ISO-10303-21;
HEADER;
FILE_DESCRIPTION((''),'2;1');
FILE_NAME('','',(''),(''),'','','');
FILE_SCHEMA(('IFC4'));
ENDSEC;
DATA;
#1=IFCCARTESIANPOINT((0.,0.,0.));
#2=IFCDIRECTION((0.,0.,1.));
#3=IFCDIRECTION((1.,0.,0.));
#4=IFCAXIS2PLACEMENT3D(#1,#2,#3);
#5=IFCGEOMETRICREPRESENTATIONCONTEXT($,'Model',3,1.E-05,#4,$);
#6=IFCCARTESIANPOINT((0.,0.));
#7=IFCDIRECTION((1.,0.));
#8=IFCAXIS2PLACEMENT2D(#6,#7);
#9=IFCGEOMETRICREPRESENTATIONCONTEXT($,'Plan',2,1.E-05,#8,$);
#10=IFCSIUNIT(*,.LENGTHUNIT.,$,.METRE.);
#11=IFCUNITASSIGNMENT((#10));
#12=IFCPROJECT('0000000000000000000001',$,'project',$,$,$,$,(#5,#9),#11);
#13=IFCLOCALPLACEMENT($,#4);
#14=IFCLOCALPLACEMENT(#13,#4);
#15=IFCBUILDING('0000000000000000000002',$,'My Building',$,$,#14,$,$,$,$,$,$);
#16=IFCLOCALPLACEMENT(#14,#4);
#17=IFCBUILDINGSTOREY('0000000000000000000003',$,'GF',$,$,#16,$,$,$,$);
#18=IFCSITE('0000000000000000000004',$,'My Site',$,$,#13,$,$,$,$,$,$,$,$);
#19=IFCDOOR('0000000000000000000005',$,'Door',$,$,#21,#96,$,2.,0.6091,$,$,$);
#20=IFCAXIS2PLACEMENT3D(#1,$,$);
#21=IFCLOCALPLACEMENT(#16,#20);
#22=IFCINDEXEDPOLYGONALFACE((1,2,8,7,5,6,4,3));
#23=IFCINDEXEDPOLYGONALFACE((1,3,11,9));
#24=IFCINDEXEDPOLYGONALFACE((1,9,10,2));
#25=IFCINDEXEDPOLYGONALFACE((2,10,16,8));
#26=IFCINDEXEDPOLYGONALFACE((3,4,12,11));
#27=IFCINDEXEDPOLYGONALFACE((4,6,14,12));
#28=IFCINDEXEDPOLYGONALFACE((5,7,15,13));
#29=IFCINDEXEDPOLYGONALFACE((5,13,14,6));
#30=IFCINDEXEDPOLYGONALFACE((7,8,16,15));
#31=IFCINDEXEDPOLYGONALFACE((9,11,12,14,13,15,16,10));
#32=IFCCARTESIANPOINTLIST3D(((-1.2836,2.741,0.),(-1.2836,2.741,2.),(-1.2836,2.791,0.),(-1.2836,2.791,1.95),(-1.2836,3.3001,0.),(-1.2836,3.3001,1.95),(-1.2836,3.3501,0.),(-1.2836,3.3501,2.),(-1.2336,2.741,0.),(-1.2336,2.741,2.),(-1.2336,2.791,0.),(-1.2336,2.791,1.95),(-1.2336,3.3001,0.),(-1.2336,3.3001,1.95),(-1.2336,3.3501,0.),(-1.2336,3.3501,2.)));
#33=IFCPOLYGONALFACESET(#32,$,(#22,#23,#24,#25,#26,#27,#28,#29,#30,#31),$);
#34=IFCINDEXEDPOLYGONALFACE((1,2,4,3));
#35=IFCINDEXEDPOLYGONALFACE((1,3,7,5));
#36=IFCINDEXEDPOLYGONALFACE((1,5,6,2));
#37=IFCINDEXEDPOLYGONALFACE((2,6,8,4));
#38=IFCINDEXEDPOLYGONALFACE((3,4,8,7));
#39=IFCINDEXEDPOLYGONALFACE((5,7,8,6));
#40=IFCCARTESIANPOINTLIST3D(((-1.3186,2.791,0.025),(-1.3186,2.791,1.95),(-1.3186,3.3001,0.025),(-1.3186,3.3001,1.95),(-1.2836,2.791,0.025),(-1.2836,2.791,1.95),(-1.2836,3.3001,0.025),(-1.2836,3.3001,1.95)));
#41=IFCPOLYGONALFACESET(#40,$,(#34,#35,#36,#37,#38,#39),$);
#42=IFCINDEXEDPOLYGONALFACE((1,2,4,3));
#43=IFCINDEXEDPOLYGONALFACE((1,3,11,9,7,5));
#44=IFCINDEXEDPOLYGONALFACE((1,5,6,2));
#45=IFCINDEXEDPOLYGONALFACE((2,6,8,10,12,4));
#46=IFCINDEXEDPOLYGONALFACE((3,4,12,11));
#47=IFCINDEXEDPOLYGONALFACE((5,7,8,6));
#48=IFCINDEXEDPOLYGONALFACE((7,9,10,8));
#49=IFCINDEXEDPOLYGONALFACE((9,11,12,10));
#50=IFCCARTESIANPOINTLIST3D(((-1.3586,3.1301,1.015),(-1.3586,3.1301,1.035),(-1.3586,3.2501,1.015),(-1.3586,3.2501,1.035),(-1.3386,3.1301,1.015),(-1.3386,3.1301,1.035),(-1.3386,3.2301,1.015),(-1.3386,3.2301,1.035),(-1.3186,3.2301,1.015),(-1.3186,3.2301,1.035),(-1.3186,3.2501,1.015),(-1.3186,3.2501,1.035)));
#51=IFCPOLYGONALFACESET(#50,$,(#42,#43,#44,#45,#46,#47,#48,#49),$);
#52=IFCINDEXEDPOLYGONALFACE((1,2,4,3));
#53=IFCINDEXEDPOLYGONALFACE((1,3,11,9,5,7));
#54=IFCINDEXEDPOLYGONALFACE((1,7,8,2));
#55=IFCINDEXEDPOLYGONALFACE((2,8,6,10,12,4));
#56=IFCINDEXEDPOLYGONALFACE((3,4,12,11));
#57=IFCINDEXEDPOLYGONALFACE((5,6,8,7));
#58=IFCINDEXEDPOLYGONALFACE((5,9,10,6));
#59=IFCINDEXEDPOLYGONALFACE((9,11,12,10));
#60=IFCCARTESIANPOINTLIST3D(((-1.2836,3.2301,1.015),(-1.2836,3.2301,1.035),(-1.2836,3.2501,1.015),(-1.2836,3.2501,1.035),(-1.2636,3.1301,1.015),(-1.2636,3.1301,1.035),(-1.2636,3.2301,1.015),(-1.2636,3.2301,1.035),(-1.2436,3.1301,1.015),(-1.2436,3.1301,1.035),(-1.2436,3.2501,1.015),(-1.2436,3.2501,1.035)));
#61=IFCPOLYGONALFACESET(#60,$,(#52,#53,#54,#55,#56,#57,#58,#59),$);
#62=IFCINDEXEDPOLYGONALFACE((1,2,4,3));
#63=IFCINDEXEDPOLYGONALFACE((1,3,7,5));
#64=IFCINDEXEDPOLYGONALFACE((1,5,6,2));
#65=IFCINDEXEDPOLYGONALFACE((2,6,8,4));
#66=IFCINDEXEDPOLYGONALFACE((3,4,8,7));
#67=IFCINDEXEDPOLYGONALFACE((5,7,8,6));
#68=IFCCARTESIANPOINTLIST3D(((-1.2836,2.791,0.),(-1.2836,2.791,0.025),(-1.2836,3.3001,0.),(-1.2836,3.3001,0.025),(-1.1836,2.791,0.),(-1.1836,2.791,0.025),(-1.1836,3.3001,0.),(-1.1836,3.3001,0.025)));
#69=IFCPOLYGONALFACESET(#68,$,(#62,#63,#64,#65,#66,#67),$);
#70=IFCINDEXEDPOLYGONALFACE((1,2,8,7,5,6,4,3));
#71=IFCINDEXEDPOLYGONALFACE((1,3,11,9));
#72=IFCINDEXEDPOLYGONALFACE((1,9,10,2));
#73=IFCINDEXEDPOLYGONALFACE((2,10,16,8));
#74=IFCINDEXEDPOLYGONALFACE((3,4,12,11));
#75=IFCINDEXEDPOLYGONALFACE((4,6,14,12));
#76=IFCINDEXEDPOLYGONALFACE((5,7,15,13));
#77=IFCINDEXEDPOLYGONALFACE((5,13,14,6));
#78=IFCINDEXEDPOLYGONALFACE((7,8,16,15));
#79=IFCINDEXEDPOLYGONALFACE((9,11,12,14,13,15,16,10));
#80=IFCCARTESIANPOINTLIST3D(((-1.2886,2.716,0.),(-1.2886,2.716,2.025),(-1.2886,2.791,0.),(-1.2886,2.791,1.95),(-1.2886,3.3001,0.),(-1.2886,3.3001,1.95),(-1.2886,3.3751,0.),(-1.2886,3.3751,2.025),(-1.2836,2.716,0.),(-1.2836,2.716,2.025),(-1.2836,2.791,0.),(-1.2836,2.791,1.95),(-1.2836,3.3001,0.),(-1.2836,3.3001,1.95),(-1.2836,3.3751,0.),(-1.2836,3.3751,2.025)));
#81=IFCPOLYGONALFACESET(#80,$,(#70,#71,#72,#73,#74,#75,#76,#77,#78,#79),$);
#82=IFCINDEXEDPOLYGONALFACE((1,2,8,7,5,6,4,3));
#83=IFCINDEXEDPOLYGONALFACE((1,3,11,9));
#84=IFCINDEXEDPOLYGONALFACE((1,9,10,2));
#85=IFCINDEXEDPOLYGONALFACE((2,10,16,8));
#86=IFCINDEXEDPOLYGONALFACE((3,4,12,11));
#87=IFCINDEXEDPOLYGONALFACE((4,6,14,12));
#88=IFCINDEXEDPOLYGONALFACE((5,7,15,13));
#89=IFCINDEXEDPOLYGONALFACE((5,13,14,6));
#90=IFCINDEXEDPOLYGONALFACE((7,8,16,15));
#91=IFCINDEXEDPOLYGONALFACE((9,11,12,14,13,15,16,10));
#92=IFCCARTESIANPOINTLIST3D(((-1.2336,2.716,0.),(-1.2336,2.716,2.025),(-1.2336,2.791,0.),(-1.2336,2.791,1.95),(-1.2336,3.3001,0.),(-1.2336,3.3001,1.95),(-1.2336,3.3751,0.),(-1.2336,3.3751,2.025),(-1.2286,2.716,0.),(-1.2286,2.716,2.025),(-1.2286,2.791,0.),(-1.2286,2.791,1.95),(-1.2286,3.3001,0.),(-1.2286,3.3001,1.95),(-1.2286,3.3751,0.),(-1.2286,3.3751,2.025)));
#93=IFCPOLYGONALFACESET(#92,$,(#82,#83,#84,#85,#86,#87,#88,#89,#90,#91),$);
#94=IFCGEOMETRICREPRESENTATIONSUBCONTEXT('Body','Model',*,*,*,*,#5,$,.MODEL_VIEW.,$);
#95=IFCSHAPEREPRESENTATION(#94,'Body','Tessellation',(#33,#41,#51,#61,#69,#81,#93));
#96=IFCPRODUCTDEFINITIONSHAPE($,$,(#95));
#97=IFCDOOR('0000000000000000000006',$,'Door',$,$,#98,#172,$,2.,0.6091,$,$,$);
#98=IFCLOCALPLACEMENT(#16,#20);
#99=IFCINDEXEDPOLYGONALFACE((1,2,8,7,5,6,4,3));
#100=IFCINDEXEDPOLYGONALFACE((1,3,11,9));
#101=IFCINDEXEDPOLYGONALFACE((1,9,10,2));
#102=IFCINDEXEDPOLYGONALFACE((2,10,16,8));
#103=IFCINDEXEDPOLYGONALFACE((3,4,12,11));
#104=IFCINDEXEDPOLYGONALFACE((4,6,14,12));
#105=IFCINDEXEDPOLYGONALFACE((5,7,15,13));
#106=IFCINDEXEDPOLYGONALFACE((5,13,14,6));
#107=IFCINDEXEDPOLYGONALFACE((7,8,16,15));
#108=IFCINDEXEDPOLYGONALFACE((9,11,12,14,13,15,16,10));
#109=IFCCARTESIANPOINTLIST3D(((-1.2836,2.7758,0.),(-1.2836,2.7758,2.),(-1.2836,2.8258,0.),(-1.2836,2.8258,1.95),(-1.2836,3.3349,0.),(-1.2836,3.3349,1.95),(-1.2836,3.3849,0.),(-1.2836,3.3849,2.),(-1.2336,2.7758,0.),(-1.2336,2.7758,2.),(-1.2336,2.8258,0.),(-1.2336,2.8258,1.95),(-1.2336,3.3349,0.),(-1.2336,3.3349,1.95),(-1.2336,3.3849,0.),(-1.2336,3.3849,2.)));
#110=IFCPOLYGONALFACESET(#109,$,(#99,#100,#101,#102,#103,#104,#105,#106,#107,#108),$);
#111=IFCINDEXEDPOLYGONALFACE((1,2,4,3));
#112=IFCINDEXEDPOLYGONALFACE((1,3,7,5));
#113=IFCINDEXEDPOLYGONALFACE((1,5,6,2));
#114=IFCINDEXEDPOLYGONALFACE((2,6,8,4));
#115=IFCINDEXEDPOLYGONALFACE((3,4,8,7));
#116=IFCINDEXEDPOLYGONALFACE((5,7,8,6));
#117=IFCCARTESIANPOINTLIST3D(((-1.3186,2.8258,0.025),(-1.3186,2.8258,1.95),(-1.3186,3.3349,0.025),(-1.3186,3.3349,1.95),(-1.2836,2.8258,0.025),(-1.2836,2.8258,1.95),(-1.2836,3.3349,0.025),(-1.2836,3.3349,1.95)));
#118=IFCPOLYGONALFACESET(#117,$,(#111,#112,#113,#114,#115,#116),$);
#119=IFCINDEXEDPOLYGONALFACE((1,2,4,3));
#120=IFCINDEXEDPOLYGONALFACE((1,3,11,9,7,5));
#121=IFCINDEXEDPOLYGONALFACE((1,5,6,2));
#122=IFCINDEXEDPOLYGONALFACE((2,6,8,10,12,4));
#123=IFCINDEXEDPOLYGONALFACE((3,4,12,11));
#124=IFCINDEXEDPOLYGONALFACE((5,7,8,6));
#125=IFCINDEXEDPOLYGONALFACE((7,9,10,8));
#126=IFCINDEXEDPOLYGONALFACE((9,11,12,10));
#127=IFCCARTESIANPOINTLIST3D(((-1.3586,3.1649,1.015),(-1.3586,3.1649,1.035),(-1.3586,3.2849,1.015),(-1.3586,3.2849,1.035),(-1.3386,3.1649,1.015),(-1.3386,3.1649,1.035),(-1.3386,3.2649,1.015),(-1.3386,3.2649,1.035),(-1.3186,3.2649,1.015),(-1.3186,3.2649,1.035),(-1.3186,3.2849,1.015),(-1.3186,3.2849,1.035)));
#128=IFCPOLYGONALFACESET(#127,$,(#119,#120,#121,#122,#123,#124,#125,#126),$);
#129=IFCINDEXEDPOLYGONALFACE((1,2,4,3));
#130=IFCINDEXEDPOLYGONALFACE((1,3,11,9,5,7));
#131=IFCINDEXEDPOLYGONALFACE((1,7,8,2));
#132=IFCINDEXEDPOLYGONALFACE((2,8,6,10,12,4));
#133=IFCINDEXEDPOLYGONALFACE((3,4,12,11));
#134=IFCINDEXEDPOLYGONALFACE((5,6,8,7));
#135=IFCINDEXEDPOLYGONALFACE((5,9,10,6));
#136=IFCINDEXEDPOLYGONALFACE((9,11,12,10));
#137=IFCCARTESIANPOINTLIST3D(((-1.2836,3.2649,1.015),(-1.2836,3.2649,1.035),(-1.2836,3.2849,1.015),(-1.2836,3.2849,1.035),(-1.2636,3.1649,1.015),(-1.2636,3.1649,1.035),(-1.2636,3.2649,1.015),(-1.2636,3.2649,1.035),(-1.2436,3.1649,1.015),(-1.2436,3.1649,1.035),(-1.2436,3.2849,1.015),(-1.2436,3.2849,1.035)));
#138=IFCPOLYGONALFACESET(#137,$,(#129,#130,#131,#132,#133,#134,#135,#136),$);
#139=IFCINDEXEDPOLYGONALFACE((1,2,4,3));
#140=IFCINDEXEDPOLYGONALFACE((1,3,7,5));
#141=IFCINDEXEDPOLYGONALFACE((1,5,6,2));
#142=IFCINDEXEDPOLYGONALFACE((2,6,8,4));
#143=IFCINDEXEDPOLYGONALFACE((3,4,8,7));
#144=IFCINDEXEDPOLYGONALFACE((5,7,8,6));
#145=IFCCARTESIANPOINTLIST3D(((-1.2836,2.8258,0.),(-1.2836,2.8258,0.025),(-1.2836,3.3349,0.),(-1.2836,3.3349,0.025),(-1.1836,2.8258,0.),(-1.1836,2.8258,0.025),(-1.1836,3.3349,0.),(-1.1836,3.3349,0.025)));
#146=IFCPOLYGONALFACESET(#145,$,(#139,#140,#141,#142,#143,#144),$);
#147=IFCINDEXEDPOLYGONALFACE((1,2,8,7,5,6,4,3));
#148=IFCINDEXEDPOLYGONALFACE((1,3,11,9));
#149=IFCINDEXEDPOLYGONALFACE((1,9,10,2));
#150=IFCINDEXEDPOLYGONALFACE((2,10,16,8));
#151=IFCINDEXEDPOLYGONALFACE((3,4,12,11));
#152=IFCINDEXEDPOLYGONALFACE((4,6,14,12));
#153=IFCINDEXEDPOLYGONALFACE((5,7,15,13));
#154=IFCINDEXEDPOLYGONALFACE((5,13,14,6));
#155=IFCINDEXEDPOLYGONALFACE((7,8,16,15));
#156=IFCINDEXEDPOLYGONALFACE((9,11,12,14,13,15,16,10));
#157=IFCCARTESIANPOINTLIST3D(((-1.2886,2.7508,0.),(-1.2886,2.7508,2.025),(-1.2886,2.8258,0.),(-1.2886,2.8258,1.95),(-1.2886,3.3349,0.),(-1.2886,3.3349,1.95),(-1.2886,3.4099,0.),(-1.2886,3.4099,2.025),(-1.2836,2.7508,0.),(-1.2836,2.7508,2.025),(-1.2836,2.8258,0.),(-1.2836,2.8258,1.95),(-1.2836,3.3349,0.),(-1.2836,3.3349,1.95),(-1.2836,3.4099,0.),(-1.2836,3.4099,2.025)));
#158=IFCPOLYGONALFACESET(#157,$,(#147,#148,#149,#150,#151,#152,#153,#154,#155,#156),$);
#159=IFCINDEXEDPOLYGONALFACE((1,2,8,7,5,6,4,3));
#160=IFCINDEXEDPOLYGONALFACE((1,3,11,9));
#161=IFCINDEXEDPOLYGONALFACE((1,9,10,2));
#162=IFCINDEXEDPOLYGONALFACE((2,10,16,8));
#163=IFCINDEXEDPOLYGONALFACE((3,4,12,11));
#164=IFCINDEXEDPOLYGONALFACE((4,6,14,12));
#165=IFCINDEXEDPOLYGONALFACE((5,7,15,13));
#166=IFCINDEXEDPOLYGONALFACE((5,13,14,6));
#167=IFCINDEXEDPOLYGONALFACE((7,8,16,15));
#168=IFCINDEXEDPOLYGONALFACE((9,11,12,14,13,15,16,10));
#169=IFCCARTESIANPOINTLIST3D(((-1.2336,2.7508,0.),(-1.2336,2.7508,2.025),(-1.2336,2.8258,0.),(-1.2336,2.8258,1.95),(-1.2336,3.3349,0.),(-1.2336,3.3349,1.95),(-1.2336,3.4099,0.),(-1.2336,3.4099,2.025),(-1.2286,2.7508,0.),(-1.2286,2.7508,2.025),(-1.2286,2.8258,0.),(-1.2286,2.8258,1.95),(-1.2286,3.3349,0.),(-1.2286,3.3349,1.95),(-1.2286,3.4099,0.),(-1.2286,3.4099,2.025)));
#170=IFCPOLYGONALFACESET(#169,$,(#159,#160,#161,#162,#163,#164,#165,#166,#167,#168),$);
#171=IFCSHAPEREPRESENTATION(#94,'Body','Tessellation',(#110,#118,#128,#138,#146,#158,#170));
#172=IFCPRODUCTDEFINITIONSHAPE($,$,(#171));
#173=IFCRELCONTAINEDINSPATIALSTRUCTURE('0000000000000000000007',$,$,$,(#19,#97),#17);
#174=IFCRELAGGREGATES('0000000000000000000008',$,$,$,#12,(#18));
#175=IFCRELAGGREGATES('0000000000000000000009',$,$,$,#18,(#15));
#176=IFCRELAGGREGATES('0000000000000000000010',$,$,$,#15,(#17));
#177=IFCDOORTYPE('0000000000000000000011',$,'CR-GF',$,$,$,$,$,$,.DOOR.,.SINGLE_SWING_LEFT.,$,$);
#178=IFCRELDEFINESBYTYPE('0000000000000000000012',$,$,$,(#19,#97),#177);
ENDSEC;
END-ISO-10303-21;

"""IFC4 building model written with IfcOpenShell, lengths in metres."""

from ifc_helpers import new_model, entity, si_unit, frame, origin_with_axes, origin_2d_with_axis, place, context, subcontext, project, spatial, line, indexed_curve, outline, extrude, shape, source, transform, mapped, type_object, type_shapes, element, save


model = new_model("IFC4")

# Units and contexts
model_context = context("Model", 3, precision=1e-05, world=origin_with_axes())
plan_context = context("Plan", 2, precision=1e-05, world=origin_2d_with_axis())
body_context_1 = subcontext(model_context, "Body", "Model", "MODEL_VIEW")
body_context_2 = subcontext(plan_context, "Body", "Plan", "PLAN_VIEW")
ifc_project = project(units=[si_unit("LENGTHUNIT", "METRE")], contexts=[model_context, plan_context])

# Site, building, storey
site_placement = place(None, origin_with_axes())
site = spatial("IfcSite", under=ifc_project, at=site_placement, Name="My Site")
building_placement = place(site_placement, origin_with_axes())
building = spatial("IfcBuilding", under=site, at=building_placement, Name="My Building")
storey_placement = place(building_placement, origin_with_axes())
storey = spatial("IfcBuildingStorey", under=building, at=storey_placement, Name="GF")

# Doors
door_type_1 = type_object("IfcDoorType", Name="CR-GF", OperationType="SINGLE_SWING_LEFT", PredefinedType="DOOR")
shared_shape_1 = source(origin_with_axes(), body_context_1, "Body", "SweptSolid", [
    extrude(outline(indexed_curve([(0.0, 0.0), (0.0, 2.0), (0.6091, 2.0), (0.6091, 0.0), (0.5591, 0.0), (0.5591, 1.95), (0.05, 1.95), (0.05, 0.0)], segments=[line(1, 2, 3, 4, 5, 6, 7, 8, 1)])), frame((0.0, 0.0, 0.0), z_axis=(0.0, -1.0, 0.0), x_axis=(1.0, 0.0, 0.0)), (0.0, 0.0, -1.0), 0.05),
    extrude(outline(indexed_curve([(0.0, 0.0), (0.5091, 0.0), (0.5091, 0.035), (0.0, 0.035)], segments=[line(1, 2, 3, 4, 1)])), frame((0.05, -0.035, 0.025), z_axis=(0.0, 0.0, 1.0), x_axis=(1.0, 0.0, 0.0)), (0.0, 0.0, 1.0), 1.925),
    extrude(outline(indexed_curve([(0.0, 0.0), (0.0, -0.04), (0.12, -0.04), (0.12, -0.02), (0.02, -0.02), (0.02, 0.0)], segments=[line(1, 2, 3, 4, 5, 6, 1)])), frame((0.1, -0.035, 1.015), z_axis=(0.0, 0.0, 1.0), x_axis=(1.0, 0.0, 0.0)), (0.0, 0.0, 1.0), 0.02),
    extrude(outline(indexed_curve([(0.0, 0.0), (0.0, 0.04), (0.12, 0.04), (0.12, 0.02), (0.02, 0.02), (0.02, 0.0)], segments=[line(1, 2, 3, 4, 5, 6, 1)])), frame((0.1, 0.0, 1.015), z_axis=(0.0, 0.0, 1.0), x_axis=(1.0, 0.0, 0.0)), (0.0, 0.0, 1.0), 0.02),
    extrude(outline(indexed_curve([(0.0, 0.0), (0.5091, 0.0), (0.5091, 0.1), (0.0, 0.1)], segments=[line(1, 2, 3, 4, 1)])), frame((0.05, 0.0, 0.0), z_axis=(0.0, 0.0, 1.0), x_axis=(1.0, 0.0, 0.0)), (0.0, 0.0, 1.0), 0.025),
    extrude(outline(indexed_curve([(0.0, 0.0), (0.0, 2.025), (0.6591, 2.025), (0.6591, 0.0), (0.5841, 0.0), (0.5841, 1.95), (0.075, 1.95), (0.075, 0.0)], segments=[line(1, 2, 3, 4, 5, 6, 7, 8, 1)])), frame((-0.025, -0.005, 0.0), z_axis=(0.0, -1.0, 0.0), x_axis=(1.0, 0.0, 0.0)), (0.0, 0.0, -1.0), 0.005),
    extrude(outline(indexed_curve([(0.0, 0.0), (0.0, 2.025), (0.6591, 2.025), (0.6591, 0.0), (0.5841, 0.0), (0.5841, 1.95), (0.075, 1.95), (0.075, 0.0)], segments=[line(1, 2, 3, 4, 5, 6, 7, 8, 1)])), frame((-0.025, 0.05, 0.0), z_axis=(0.0, -1.0, 0.0), x_axis=(1.0, 0.0, 0.0)), (0.0, 0.0, -1.0), 0.005),
])
shared_shape_2 = source(origin_with_axes(), body_context_2, "Body", "Curve2D", [
    entity("IfcIndexedPolyCurve", entity("IfcCartesianPointList2D", [[0.0, 0.0], [0.05, 0.0], [0.05, 0.05], [0.0, 0.05]]), [entity("IfcLineIndex", [1, 2, 3, 4, 1])]),
    entity("IfcIndexedPolyCurve", entity("IfcCartesianPointList2D", [[0.6091, 0.0], [0.5591, 0.0], [0.5591, 0.05], [0.6091, 0.05]]), [entity("IfcLineIndex", [1, 2, 3, 4, 1])]),
    entity("IfcIndexedPolyCurve", entity("IfcCartesianPointList2D", [[0.8137, -0.035], [0.3046, -0.035], [0.3046, 0.0], [0.8137, 0.0]]), [entity("IfcLineIndex", [1, 2, 3, 4, 1])]),
])
type_shapes(door_type_1, [shared_shape_1, shared_shape_2])
placement_1 = place(storey_placement, frame((-1.1836, 2.64, 0.0), z_axis=(0.0, 0.0, 1.0), x_axis=(0.0, 1.0, 0.0)))
placement_2 = place(placement_1, frame((0.7101, 0.1, 0.0), z_axis=(0.0, 0.0, 1.0), x_axis=(-1.0, 0.0, 0.0)))
door_1_placement = place(placement_2, frame((0.0, 0.0, 0.0), z_axis=(0.0, 0.0, 1.0), x_axis=(1.0, 0.0, 0.0)))
element("IfcDoor", 1, at=door_1_placement, inside=storey, type_object=door_type_1, Name="Door", OverallHeight=2.0, OverallWidth=0.6091, shapes=[
    shape(body_context_1, "Body", "MappedRepresentation", [mapped(shared_shape_1, transform((0.0, 0.0, 0.0), x_axis=(1.0, 0.0, 0.0), y_axis=(0.0, 1.0, 0.0), z_axis=(0.0, 0.0, 1.0), scale=1.0))]),
    shape(body_context_2, "Body", "MappedRepresentation", [mapped(shared_shape_2, transform((0.0, 0.0, 0.0), x_axis=(1.0, 0.0, 0.0), y_axis=(0.0, 1.0, 0.0), z_axis=(0.0, 0.0, 1.0), scale=1.0))]),
])
placement_3 = place(placement_1, frame((0.745, 0.1, 0.0), z_axis=(0.0, 0.0, 1.0), x_axis=(-1.0, 0.0, 0.0)))
door_2_placement = place(placement_3, frame((0.0, 0.0, 0.0), z_axis=(0.0, 0.0, 1.0), x_axis=(1.0, 0.0, 0.0)))
element("IfcDoor", 2, at=door_2_placement, inside=storey, type_object=door_type_1, Name="Door", OverallHeight=2.0, OverallWidth=0.6091, shapes=[
    shape(body_context_1, "Body", "MappedRepresentation", [mapped(shared_shape_1, transform((0.0, 0.0, 0.0), x_axis=(1.0, 0.0, 0.0), y_axis=(0.0, 1.0, 0.0), z_axis=(0.0, 0.0, 1.0), scale=1.0))]),
    shape(body_context_2, "Body", "MappedRepresentation", [mapped(shared_shape_2, transform((0.0, 0.0, 0.0), x_axis=(1.0, 0.0, 0.0), y_axis=(0.0, 1.0, 0.0), z_axis=(0.0, 0.0, 1.0), scale=1.0))]),
])

save(model, "model.ifc")
